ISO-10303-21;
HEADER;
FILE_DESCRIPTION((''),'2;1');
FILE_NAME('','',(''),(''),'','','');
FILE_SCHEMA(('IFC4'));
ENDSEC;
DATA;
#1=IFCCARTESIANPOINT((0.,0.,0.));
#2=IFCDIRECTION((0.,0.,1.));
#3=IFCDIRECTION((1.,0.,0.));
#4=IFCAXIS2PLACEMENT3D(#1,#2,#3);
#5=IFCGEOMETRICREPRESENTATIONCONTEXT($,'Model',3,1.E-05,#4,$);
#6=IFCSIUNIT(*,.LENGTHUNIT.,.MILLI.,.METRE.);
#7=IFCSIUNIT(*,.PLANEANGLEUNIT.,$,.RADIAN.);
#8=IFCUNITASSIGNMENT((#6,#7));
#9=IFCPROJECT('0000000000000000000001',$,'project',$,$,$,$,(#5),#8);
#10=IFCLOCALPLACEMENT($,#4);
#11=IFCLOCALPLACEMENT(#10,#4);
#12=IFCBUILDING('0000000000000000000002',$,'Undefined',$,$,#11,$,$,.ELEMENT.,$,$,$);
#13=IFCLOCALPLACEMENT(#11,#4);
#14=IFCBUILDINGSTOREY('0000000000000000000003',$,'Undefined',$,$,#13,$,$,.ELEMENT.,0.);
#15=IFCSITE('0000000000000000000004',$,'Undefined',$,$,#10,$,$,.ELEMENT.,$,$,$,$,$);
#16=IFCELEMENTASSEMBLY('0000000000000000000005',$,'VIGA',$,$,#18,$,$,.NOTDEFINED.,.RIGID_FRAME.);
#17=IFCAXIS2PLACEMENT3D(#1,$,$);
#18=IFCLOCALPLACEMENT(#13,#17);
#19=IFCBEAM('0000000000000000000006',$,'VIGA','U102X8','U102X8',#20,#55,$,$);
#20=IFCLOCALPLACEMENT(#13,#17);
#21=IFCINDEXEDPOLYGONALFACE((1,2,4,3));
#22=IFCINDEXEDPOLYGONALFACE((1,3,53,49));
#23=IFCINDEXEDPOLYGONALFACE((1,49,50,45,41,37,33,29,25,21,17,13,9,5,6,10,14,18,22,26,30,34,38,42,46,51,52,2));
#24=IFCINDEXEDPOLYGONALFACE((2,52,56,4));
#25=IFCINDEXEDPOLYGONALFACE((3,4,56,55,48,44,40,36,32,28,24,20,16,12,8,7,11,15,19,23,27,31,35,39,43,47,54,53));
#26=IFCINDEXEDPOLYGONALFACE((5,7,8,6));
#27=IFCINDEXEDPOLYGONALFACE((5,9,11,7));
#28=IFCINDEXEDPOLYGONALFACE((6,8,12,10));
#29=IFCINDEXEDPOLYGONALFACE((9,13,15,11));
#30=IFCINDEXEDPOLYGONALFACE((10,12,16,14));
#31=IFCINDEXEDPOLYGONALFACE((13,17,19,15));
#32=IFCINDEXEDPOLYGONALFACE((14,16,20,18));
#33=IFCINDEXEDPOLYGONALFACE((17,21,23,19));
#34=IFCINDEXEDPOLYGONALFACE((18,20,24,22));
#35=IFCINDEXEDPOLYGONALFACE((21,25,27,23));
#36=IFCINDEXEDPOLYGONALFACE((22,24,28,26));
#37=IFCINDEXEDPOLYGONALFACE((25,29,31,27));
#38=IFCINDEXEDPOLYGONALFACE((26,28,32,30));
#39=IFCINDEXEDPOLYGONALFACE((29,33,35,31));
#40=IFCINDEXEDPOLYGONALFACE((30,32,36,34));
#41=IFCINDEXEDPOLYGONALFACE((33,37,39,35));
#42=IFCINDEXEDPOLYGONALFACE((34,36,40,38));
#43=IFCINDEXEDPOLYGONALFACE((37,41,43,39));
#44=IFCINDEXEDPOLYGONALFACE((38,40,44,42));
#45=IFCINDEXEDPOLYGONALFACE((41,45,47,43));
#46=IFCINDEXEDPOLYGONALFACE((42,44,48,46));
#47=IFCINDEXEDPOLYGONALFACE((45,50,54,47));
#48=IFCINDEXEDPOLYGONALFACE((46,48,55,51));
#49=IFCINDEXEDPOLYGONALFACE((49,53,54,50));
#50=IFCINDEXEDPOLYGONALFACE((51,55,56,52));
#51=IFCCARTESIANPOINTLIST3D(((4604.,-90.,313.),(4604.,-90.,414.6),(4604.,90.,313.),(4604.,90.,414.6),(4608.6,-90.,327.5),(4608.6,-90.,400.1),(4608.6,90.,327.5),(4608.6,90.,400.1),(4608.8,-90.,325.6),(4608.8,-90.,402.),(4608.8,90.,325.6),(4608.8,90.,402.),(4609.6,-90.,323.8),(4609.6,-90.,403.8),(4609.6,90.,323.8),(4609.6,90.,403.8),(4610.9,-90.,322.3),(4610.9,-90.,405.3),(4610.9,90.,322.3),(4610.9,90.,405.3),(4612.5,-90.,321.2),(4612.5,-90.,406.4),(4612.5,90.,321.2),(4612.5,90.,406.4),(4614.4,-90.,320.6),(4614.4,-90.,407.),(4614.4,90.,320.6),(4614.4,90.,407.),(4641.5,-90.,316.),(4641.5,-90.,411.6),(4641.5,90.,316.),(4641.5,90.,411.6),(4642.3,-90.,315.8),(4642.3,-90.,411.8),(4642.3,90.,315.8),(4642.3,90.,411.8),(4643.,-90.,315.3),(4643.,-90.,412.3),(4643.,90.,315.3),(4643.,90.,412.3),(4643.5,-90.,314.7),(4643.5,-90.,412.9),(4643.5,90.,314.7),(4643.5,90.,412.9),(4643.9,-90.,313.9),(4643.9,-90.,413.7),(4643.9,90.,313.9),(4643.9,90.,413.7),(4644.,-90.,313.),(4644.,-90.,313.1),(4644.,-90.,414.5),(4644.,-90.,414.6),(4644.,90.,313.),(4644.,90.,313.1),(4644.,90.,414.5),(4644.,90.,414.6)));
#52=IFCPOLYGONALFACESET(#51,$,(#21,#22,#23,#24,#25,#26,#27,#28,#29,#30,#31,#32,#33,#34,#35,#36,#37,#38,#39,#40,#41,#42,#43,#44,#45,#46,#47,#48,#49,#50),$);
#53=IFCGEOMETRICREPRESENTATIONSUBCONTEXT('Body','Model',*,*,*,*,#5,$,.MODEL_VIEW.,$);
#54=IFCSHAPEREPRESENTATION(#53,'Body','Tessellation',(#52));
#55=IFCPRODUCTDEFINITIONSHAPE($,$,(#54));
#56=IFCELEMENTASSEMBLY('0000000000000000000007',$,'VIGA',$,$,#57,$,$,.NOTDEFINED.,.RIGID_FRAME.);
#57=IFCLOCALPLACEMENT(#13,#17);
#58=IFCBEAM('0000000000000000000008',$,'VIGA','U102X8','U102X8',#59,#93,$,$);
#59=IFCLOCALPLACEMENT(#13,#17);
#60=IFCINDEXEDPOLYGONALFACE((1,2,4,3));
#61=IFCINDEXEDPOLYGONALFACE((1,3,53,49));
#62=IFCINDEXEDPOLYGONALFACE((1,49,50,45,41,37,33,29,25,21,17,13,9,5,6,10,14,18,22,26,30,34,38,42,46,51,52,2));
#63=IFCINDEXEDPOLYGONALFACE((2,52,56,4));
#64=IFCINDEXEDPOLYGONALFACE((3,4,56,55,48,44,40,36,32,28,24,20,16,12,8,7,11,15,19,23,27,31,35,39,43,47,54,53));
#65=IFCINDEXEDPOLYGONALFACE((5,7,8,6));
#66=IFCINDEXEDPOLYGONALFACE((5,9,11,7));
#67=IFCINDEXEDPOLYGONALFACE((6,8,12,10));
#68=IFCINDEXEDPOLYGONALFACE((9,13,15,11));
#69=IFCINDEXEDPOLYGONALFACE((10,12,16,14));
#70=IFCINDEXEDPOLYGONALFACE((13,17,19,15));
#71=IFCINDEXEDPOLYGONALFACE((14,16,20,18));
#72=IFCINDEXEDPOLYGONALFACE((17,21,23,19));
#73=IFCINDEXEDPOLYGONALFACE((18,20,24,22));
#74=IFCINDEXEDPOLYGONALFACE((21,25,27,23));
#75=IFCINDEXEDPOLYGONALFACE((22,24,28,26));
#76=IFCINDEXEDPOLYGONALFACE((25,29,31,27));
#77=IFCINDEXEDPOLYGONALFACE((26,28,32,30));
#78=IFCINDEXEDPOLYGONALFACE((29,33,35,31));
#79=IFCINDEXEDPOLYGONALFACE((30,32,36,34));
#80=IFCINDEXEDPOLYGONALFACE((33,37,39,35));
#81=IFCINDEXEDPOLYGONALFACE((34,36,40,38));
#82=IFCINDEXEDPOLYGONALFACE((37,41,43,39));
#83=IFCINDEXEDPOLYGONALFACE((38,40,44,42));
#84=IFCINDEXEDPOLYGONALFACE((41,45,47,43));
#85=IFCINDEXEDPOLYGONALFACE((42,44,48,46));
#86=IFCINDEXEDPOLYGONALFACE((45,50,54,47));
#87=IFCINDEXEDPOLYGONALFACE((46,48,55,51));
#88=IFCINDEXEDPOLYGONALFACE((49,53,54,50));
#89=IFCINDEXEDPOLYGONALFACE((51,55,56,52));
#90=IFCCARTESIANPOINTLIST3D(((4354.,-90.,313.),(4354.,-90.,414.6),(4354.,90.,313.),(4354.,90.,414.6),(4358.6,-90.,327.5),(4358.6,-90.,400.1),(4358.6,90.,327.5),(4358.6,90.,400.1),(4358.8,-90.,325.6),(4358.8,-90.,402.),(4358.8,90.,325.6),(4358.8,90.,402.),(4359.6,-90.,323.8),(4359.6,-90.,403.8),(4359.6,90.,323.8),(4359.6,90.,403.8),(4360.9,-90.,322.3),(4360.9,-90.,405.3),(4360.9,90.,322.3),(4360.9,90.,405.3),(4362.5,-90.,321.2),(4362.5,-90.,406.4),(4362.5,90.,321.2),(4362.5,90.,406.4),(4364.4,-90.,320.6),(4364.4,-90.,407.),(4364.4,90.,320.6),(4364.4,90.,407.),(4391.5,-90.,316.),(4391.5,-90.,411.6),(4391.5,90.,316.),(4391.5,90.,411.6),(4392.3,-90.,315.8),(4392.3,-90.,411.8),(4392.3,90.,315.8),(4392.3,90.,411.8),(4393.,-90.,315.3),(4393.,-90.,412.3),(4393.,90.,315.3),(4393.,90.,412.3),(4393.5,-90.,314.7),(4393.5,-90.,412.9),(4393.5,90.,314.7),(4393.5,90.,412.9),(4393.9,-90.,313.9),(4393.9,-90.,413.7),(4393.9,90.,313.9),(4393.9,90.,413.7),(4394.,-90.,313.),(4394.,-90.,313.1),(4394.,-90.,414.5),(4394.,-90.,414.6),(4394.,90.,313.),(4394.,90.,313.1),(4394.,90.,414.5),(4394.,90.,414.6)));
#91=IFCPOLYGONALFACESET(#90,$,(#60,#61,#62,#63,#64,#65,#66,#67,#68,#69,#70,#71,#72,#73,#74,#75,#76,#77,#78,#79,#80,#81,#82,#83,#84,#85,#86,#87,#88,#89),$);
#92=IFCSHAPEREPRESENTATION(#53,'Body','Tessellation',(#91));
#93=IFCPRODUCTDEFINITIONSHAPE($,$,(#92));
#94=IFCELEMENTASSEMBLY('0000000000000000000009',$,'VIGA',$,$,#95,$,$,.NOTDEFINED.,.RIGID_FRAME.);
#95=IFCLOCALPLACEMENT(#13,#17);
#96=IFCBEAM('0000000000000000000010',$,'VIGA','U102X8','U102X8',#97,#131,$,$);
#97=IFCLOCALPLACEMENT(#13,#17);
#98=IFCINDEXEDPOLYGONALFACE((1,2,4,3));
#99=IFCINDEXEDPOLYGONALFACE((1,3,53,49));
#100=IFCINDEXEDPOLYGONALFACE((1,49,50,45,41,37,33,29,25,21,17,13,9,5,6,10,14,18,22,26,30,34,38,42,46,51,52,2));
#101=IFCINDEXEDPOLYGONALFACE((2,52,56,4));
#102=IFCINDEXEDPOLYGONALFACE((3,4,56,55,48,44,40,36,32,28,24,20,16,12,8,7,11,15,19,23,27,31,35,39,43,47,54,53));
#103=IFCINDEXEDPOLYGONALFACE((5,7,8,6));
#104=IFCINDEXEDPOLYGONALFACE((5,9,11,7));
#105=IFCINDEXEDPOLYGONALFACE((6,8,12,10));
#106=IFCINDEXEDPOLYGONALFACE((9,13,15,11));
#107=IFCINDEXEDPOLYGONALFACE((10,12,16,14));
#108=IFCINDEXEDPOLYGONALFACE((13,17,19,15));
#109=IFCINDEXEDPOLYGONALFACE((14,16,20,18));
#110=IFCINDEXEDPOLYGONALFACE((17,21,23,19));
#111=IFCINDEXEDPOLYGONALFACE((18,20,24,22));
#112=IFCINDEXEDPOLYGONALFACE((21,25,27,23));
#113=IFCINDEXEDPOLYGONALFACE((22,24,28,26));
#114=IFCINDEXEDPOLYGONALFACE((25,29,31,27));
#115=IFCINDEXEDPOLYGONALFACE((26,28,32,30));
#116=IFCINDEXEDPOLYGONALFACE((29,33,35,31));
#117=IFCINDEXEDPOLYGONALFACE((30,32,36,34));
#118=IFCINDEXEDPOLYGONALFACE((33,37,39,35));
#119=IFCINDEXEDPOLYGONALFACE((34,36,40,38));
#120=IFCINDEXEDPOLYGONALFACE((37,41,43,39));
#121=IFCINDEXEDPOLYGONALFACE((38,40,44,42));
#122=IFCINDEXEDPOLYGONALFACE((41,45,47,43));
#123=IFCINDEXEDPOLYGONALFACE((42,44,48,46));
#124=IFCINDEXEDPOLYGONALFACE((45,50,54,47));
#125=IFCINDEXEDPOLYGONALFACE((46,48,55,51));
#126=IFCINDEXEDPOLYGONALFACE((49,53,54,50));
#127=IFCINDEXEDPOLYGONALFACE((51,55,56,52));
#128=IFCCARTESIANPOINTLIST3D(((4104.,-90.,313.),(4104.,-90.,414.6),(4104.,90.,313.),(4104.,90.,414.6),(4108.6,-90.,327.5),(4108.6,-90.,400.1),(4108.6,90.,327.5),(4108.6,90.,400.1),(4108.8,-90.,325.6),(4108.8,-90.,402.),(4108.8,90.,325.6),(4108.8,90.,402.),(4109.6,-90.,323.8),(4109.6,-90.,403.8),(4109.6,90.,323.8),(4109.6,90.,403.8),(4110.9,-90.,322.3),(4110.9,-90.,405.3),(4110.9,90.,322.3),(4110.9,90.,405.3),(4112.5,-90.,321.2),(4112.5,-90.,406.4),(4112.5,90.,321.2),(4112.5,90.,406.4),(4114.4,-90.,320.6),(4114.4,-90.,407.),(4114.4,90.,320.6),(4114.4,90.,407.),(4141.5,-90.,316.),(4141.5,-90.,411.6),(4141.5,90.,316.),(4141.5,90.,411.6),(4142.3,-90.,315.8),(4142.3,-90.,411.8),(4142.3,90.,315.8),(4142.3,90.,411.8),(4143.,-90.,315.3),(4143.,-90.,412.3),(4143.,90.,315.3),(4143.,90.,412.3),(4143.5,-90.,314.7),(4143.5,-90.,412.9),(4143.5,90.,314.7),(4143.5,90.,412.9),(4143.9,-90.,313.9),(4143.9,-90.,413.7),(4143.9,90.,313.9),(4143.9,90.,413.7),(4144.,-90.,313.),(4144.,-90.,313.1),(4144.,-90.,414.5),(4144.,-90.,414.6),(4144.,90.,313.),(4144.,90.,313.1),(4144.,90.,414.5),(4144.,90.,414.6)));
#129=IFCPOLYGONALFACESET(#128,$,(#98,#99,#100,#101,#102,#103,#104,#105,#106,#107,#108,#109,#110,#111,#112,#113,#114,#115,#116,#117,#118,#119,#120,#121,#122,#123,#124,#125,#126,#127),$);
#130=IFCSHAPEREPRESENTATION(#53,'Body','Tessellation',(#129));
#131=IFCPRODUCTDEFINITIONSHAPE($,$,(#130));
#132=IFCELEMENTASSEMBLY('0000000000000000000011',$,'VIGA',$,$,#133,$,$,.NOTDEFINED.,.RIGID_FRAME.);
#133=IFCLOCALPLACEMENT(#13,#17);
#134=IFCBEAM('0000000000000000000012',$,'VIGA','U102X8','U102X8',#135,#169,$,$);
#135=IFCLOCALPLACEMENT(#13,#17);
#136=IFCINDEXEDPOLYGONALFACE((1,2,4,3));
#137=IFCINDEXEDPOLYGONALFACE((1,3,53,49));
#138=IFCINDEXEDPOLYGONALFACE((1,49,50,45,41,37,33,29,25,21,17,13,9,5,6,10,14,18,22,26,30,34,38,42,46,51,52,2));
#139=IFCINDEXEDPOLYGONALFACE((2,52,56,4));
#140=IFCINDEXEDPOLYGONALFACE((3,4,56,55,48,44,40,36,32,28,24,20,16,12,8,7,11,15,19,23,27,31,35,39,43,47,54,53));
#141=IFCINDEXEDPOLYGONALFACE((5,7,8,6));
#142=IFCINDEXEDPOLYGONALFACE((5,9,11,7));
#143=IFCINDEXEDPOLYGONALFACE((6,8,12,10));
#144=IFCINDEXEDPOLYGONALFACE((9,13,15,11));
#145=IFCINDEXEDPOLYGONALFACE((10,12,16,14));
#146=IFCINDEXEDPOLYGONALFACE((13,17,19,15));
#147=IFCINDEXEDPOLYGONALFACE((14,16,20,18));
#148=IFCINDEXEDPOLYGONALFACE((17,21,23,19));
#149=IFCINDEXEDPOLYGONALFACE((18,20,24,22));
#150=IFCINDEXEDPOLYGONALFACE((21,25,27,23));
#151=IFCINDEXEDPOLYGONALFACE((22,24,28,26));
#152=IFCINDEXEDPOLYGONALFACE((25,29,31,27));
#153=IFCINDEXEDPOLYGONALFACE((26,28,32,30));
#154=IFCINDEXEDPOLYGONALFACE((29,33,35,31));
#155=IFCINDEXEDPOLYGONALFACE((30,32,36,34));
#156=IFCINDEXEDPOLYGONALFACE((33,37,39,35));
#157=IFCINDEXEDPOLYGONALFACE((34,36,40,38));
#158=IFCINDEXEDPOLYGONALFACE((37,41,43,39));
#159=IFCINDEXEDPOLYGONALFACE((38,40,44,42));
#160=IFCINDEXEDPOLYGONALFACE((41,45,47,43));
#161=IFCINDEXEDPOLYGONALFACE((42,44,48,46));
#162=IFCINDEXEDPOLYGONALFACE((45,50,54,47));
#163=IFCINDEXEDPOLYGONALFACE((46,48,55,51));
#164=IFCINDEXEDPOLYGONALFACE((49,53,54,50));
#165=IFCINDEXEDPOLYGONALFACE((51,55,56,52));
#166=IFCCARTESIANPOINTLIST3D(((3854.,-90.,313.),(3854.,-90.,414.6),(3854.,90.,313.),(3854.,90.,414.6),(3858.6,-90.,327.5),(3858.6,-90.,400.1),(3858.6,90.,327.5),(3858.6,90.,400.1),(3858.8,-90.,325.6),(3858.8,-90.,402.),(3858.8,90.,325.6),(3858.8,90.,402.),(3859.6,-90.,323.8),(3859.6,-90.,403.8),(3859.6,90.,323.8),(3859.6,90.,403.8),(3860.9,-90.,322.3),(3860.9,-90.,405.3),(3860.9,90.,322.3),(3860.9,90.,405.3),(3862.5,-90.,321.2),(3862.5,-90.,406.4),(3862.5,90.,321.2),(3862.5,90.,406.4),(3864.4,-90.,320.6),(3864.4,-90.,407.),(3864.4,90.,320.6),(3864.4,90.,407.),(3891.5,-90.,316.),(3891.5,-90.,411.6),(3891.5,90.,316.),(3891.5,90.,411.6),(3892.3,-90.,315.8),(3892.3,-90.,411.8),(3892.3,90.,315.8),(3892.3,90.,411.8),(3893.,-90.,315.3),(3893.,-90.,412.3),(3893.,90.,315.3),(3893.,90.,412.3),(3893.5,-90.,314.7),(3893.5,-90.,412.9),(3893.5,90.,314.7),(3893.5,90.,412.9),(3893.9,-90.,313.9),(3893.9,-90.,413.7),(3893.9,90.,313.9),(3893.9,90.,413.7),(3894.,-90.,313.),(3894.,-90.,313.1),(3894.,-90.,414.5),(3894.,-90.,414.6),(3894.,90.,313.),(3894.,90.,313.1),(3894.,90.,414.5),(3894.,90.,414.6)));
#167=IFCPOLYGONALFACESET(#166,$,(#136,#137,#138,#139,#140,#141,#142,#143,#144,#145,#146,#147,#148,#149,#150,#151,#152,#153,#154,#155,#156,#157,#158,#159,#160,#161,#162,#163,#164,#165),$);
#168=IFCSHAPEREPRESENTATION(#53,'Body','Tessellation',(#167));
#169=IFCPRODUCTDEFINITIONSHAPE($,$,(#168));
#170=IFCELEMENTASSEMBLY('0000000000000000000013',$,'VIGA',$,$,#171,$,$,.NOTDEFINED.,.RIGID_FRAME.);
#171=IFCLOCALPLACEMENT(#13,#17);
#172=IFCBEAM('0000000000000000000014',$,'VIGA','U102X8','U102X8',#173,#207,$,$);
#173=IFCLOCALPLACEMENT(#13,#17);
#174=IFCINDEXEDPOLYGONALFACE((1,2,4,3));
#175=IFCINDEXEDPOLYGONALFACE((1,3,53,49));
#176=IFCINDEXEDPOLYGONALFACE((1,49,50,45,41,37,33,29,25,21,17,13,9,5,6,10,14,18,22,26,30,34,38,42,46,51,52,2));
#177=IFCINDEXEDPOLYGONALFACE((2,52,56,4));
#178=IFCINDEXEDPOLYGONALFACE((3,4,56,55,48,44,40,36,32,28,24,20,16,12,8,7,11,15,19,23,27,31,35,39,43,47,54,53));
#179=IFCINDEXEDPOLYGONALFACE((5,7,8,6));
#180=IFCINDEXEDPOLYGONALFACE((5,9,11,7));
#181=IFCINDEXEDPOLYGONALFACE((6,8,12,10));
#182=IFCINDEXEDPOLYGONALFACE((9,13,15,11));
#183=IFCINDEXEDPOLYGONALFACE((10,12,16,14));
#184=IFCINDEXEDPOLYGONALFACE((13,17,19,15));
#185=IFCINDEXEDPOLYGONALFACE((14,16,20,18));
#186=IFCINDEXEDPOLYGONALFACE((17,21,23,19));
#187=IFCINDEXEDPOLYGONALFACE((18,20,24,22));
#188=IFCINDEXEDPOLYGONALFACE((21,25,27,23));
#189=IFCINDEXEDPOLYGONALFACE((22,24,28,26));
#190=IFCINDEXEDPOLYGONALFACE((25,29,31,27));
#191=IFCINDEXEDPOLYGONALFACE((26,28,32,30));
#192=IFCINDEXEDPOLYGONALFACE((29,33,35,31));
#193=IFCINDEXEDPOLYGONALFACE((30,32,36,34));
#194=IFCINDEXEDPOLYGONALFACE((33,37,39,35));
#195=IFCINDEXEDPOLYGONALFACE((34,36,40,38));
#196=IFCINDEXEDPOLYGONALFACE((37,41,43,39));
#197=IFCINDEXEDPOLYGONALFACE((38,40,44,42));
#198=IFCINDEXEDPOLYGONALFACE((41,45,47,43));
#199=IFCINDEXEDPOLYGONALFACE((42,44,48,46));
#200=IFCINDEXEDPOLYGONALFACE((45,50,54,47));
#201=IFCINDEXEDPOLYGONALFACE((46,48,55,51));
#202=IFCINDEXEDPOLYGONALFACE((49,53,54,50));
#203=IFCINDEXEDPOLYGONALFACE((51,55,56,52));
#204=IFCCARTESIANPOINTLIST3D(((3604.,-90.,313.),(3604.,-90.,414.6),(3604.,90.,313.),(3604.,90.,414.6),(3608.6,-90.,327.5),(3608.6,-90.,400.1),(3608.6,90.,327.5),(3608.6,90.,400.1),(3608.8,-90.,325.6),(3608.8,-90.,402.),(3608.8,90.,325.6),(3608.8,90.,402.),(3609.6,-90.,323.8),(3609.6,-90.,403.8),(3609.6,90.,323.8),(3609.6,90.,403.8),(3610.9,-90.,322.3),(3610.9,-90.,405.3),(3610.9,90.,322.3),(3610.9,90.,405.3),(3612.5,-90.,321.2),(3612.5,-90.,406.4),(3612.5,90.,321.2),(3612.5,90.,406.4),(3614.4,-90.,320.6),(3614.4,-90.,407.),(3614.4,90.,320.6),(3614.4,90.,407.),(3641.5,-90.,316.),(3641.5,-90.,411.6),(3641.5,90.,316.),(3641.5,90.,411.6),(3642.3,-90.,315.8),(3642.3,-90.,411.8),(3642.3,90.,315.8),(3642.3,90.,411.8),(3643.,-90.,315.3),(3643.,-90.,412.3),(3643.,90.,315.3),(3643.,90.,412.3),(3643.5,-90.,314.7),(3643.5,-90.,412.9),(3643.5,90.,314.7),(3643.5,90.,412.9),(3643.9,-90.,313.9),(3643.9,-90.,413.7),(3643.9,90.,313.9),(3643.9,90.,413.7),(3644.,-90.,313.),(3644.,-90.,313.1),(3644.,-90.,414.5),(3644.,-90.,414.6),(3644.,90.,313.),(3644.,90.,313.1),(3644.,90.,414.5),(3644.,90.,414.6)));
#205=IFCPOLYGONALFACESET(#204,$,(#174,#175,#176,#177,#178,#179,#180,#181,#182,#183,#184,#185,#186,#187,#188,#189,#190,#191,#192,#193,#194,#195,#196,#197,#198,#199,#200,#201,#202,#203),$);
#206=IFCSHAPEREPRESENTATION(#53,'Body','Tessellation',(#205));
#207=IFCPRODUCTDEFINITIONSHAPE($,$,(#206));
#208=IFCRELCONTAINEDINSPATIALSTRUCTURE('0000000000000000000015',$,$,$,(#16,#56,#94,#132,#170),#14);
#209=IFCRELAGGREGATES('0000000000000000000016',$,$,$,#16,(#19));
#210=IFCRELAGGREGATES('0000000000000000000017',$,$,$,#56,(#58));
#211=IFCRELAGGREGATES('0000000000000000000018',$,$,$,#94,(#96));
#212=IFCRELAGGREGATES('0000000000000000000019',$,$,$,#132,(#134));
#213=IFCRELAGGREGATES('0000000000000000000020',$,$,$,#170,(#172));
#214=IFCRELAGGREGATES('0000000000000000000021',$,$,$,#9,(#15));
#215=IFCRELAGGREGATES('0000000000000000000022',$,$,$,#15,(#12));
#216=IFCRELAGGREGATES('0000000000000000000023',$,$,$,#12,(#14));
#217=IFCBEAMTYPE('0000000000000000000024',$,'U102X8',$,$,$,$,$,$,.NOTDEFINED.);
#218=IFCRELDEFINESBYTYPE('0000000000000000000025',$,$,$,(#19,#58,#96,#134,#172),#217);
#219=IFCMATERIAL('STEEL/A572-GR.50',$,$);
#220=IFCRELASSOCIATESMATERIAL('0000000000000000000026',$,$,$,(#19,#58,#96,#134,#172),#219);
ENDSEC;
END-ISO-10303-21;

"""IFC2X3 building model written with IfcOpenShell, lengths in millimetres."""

from ifc_helpers import new_model, si_unit, frame, origin_with_axes, origin_2d_with_axis, place, context, subcontext, project, spatial, u_section, extrude, material, type_object, element, aggregate, save


model = new_model("IFC2X3")

# Units and contexts
model_context = context("Model", 3, precision=1e-05, world=origin_with_axes())
body_context = subcontext(model_context, "Body", "Model", "MODEL_VIEW")
ifc_project = project(units=[si_unit("LENGTHUNIT", "METRE", prefix="MILLI"), si_unit("PLANEANGLEUNIT", "RADIAN")], contexts=[model_context])

# Site, building, storey
site_placement = place(None, origin_with_axes())
site = spatial("IfcSite", under=ifc_project, at=site_placement, Name="Undefined", CompositionType="ELEMENT")
building_placement = place(site_placement, origin_with_axes())
building = spatial("IfcBuilding", under=site, at=building_placement, Name="Undefined", CompositionType="ELEMENT")
storey_placement = place(building_placement, origin_with_axes())
storey = spatial("IfcBuildingStorey", under=building, at=storey_placement, Name="Undefined", CompositionType="ELEMENT", Elevation=0.0)

# Element assemblies, beams
ifc_material_1 = material(Name="STEEL/A572-GR.50")
beam_type_1 = type_object("IfcBeamType", Name="U102X8", PredefinedType="NOTDEFINED")
assembly_1_placement = place(storey_placement, origin_with_axes())
assembly_1 = element("IfcElementAssembly", 1, at=assembly_1_placement, inside=storey, Name="VIGA", AssemblyPlace="NOTDEFINED", PredefinedType="RIGID_FRAME")
beam_1_placement = place(assembly_1_placement, frame((4624.0, -90.0, 363.8), z_axis=(0.0, 0.0, 1.0), x_axis=(0.0, 1.0, 0.0)))
beam_1 = element("IfcBeam", 2, at=beam_1_placement, type_object=beam_type_1, material=ifc_material_1, Name="VIGA", Description="U102X8", ObjectType="U102X8", context=body_context, shape_type="SweptSolid", body=[
    extrude(u_section(Depth=101.6, FlangeWidth=40.0, WebThickness=4.6, FlangeThickness=6.0, FilletRadius=7.0, EdgeRadius=3.0, FlangeSlope=0.16839, at=origin_2d_with_axis()), frame((180.0, 0.0, 0.0), z_axis=(-1.0, 0.0, 0.0), x_axis=(0.0, -1.0, 0.0)), (0.0, 0.0, 1.0), 180.0),
])
aggregate(assembly_1, [beam_1])
assembly_2_placement = place(storey_placement, origin_with_axes())
assembly_2 = element("IfcElementAssembly", 3, at=assembly_2_placement, inside=storey, Name="VIGA", AssemblyPlace="NOTDEFINED", PredefinedType="RIGID_FRAME")
beam_2_placement = place(assembly_2_placement, frame((4374.0, -90.0, 363.8), z_axis=(0.0, 0.0, 1.0), x_axis=(0.0, 1.0, 0.0)))
beam_2 = element("IfcBeam", 4, at=beam_2_placement, type_object=beam_type_1, material=ifc_material_1, Name="VIGA", Description="U102X8", ObjectType="U102X8", context=body_context, shape_type="SweptSolid", body=[
    extrude(u_section(Depth=101.6, FlangeWidth=40.0, WebThickness=4.6, FlangeThickness=6.0, FilletRadius=7.0, EdgeRadius=3.0, FlangeSlope=0.16839, at=origin_2d_with_axis()), frame((180.0, 0.0, 0.0), z_axis=(-1.0, 0.0, 0.0), x_axis=(0.0, -1.0, 0.0)), (0.0, 0.0, 1.0), 180.0),
])
aggregate(assembly_2, [beam_2])
assembly_3_placement = place(storey_placement, origin_with_axes())
assembly_3 = element("IfcElementAssembly", 5, at=assembly_3_placement, inside=storey, Name="VIGA", AssemblyPlace="NOTDEFINED", PredefinedType="RIGID_FRAME")
beam_3_placement = place(assembly_3_placement, frame((4124.0, -90.0, 363.8), z_axis=(0.0, 0.0, 1.0), x_axis=(0.0, 1.0, 0.0)))
beam_3 = element("IfcBeam", 6, at=beam_3_placement, type_object=beam_type_1, material=ifc_material_1, Name="VIGA", Description="U102X8", ObjectType="U102X8", context=body_context, shape_type="SweptSolid", body=[
    extrude(u_section(Depth=101.6, FlangeWidth=40.0, WebThickness=4.6, FlangeThickness=6.0, FilletRadius=7.0, EdgeRadius=3.0, FlangeSlope=0.16839, at=origin_2d_with_axis()), frame((180.0, 0.0, 0.0), z_axis=(-1.0, 0.0, 0.0), x_axis=(0.0, -1.0, 0.0)), (0.0, 0.0, 1.0), 180.0),
])
aggregate(assembly_3, [beam_3])
assembly_4_placement = place(storey_placement, origin_with_axes())
assembly_4 = element("IfcElementAssembly", 7, at=assembly_4_placement, inside=storey, Name="VIGA", AssemblyPlace="NOTDEFINED", PredefinedType="RIGID_FRAME")
beam_4_placement = place(assembly_4_placement, frame((3874.0, -90.0, 363.8), z_axis=(0.0, 0.0, 1.0), x_axis=(0.0, 1.0, 0.0)))
beam_4 = element("IfcBeam", 8, at=beam_4_placement, type_object=beam_type_1, material=ifc_material_1, Name="VIGA", Description="U102X8", ObjectType="U102X8", context=body_context, shape_type="SweptSolid", body=[
    extrude(u_section(Depth=101.6, FlangeWidth=40.0, WebThickness=4.6, FlangeThickness=6.0, FilletRadius=7.0, EdgeRadius=3.0, FlangeSlope=0.16839, at=origin_2d_with_axis()), frame((180.0, 0.0, 0.0), z_axis=(-1.0, 0.0, 0.0), x_axis=(0.0, -1.0, 0.0)), (0.0, 0.0, 1.0), 180.0),
])
aggregate(assembly_4, [beam_4])
assembly_5_placement = place(storey_placement, origin_with_axes())
assembly_5 = element("IfcElementAssembly", 9, at=assembly_5_placement, inside=storey, Name="VIGA", AssemblyPlace="NOTDEFINED", PredefinedType="RIGID_FRAME")
beam_5_placement = place(assembly_5_placement, frame((3624.0, -90.0, 363.8), z_axis=(0.0, 0.0, 1.0), x_axis=(0.0, 1.0, 0.0)))
beam_5 = element("IfcBeam", 10, at=beam_5_placement, type_object=beam_type_1, material=ifc_material_1, Name="VIGA", Description="U102X8", ObjectType="U102X8", context=body_context, shape_type="SweptSolid", body=[
    extrude(u_section(Depth=101.6, FlangeWidth=40.0, WebThickness=4.6, FlangeThickness=6.0, FilletRadius=7.0, EdgeRadius=3.0, FlangeSlope=0.16839, at=origin_2d_with_axis()), frame((180.0, 0.0, 0.0), z_axis=(-1.0, 0.0, 0.0), x_axis=(0.0, -1.0, 0.0)), (0.0, 0.0, 1.0), 180.0),
])
aggregate(assembly_5, [beam_5])

save(model, "model.ifc")
